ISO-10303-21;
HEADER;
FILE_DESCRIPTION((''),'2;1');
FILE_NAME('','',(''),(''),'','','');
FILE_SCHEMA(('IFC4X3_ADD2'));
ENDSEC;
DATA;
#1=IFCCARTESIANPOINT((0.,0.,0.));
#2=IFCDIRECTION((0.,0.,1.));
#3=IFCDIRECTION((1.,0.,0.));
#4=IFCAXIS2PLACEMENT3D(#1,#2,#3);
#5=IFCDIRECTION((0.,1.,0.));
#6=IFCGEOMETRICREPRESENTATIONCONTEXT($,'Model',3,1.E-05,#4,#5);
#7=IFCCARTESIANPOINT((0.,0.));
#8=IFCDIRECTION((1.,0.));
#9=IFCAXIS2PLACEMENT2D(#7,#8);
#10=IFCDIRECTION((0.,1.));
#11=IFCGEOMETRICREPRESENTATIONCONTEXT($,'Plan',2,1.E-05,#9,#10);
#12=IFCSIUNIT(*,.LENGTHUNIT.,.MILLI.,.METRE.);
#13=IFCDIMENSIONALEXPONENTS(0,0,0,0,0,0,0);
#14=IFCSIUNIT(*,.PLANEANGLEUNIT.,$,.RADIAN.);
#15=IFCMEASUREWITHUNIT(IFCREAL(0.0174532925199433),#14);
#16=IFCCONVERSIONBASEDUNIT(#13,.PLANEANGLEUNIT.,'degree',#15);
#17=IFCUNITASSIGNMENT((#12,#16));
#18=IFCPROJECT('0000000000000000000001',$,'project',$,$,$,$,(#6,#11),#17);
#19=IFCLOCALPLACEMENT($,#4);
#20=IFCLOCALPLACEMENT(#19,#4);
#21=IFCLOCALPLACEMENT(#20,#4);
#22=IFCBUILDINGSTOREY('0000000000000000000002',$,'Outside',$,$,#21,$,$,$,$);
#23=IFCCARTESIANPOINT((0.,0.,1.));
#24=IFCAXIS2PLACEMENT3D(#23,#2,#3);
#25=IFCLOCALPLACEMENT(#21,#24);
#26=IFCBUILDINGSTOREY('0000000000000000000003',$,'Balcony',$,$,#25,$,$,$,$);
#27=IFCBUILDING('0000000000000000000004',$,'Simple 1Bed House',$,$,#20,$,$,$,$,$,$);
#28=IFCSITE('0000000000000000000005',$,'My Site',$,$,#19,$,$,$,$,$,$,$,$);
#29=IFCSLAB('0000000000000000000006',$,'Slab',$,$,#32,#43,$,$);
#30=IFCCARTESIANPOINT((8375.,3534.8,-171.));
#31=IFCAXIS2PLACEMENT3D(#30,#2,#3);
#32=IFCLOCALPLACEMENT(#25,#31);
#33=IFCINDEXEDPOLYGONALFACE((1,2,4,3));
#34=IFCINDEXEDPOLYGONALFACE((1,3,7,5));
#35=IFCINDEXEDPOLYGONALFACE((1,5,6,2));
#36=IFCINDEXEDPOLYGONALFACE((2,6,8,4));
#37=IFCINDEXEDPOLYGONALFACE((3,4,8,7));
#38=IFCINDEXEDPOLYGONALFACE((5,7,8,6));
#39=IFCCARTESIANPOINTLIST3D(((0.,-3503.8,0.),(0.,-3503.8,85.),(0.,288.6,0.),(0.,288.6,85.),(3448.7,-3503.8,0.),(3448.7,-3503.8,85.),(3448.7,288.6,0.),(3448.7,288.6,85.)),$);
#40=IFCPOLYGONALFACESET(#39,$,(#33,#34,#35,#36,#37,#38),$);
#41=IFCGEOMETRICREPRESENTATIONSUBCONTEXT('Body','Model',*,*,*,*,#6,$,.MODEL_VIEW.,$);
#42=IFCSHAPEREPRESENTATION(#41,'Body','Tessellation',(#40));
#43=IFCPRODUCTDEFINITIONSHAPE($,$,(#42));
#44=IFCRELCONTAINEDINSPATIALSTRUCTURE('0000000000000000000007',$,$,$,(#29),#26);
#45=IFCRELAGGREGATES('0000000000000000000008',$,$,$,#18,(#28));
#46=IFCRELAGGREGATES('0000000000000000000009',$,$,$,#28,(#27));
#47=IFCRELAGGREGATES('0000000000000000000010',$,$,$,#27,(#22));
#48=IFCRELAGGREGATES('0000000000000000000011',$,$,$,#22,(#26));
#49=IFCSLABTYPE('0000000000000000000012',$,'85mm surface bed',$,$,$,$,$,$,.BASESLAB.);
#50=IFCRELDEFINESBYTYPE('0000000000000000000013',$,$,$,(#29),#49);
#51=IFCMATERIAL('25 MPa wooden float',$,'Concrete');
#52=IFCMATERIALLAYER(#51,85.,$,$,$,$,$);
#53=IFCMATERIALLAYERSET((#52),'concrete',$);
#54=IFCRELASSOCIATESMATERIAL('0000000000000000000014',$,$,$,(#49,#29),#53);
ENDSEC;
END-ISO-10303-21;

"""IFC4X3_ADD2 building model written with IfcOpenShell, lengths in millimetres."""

from ifc_helpers import new_model, entity, si_unit, converted_unit, direction, frame, origin_with_axes, origin_2d_with_axis, place, context, subcontext, project, spatial, indexed_curve, outline, extrude, material, layer, layer_set, layer_usage, type_object, element, save


model = new_model("IFC4X3_ADD2")

# Units and contexts
model_context = context("Model", 3, precision=1e-05, world=origin_with_axes(), true_north=direction((0.0, 1.0, 0.0)))
plan_context = context("Plan", 2, precision=1e-05, world=origin_2d_with_axis(), true_north=direction((0.0, 1.0)))
body_context = subcontext(model_context, "Body", "Model", "MODEL_VIEW")
ifc_project = project(units=[si_unit("LENGTHUNIT", "METRE", prefix="MILLI"), converted_unit("PLANEANGLEUNIT", "degree", entity("IfcReal", 0.0174532925199433), si_unit("PLANEANGLEUNIT", "RADIAN"), dimensions=[0, 0, 0, 0, 0, 0, 0])], contexts=[model_context, plan_context])

# Site, building, storeys
site_placement = place(None, origin_with_axes())
site = spatial("IfcSite", under=ifc_project, at=site_placement, Name="My Site")
building_placement = place(site_placement, origin_with_axes())
building = spatial("IfcBuilding", under=site, at=building_placement, Name="Simple 1Bed House")
storey_1_placement = place(building_placement, origin_with_axes())
storey_1 = spatial("IfcBuildingStorey", under=building, at=storey_1_placement, Name="Outside")
storey_2_placement = place(storey_1_placement, frame((0.0, 0.0, 1.0), z_axis=(0.0, 0.0, 1.0), x_axis=(1.0, 0.0, 0.0)))
storey_2 = spatial("IfcBuildingStorey", under=storey_1, at=storey_2_placement, Name="Balcony")

# Slab
ifc_material_1 = material(Name="25 MPa wooden float", Category="Concrete")
ifc_layer_1 = layer(ifc_material_1, 85.0)
ifc_layer_set_1 = layer_set([ifc_layer_1], Name="concrete")
ifc_layer_usage_1 = layer_usage(ifc_layer_set_1, "AXIS3", "POSITIVE", 0.0)
slab_type = type_object("IfcSlabType", Name="85mm surface bed", PredefinedType="BASESLAB", material=ifc_layer_set_1)
slab_placement = place(storey_2_placement, frame((8375.0, 3534.8, -171.0), z_axis=(0.0, 0.0, 1.0), x_axis=(1.0, 0.0, 0.0)))
element("IfcSlab", 1, at=slab_placement, inside=storey_2, type_object=slab_type, material=ifc_layer_usage_1, Name="Slab", context=body_context, shape_type="SweptSolid", body=[
    extrude(outline(indexed_curve([(3448.7, 288.6), (3448.7, -3503.8), (0.0, -3503.8), (0.0, 288.6), (3448.7, 288.6)])), None, (0.0, 0.0, 1.0), 85.0),
])

save(model, "model.ifc")
